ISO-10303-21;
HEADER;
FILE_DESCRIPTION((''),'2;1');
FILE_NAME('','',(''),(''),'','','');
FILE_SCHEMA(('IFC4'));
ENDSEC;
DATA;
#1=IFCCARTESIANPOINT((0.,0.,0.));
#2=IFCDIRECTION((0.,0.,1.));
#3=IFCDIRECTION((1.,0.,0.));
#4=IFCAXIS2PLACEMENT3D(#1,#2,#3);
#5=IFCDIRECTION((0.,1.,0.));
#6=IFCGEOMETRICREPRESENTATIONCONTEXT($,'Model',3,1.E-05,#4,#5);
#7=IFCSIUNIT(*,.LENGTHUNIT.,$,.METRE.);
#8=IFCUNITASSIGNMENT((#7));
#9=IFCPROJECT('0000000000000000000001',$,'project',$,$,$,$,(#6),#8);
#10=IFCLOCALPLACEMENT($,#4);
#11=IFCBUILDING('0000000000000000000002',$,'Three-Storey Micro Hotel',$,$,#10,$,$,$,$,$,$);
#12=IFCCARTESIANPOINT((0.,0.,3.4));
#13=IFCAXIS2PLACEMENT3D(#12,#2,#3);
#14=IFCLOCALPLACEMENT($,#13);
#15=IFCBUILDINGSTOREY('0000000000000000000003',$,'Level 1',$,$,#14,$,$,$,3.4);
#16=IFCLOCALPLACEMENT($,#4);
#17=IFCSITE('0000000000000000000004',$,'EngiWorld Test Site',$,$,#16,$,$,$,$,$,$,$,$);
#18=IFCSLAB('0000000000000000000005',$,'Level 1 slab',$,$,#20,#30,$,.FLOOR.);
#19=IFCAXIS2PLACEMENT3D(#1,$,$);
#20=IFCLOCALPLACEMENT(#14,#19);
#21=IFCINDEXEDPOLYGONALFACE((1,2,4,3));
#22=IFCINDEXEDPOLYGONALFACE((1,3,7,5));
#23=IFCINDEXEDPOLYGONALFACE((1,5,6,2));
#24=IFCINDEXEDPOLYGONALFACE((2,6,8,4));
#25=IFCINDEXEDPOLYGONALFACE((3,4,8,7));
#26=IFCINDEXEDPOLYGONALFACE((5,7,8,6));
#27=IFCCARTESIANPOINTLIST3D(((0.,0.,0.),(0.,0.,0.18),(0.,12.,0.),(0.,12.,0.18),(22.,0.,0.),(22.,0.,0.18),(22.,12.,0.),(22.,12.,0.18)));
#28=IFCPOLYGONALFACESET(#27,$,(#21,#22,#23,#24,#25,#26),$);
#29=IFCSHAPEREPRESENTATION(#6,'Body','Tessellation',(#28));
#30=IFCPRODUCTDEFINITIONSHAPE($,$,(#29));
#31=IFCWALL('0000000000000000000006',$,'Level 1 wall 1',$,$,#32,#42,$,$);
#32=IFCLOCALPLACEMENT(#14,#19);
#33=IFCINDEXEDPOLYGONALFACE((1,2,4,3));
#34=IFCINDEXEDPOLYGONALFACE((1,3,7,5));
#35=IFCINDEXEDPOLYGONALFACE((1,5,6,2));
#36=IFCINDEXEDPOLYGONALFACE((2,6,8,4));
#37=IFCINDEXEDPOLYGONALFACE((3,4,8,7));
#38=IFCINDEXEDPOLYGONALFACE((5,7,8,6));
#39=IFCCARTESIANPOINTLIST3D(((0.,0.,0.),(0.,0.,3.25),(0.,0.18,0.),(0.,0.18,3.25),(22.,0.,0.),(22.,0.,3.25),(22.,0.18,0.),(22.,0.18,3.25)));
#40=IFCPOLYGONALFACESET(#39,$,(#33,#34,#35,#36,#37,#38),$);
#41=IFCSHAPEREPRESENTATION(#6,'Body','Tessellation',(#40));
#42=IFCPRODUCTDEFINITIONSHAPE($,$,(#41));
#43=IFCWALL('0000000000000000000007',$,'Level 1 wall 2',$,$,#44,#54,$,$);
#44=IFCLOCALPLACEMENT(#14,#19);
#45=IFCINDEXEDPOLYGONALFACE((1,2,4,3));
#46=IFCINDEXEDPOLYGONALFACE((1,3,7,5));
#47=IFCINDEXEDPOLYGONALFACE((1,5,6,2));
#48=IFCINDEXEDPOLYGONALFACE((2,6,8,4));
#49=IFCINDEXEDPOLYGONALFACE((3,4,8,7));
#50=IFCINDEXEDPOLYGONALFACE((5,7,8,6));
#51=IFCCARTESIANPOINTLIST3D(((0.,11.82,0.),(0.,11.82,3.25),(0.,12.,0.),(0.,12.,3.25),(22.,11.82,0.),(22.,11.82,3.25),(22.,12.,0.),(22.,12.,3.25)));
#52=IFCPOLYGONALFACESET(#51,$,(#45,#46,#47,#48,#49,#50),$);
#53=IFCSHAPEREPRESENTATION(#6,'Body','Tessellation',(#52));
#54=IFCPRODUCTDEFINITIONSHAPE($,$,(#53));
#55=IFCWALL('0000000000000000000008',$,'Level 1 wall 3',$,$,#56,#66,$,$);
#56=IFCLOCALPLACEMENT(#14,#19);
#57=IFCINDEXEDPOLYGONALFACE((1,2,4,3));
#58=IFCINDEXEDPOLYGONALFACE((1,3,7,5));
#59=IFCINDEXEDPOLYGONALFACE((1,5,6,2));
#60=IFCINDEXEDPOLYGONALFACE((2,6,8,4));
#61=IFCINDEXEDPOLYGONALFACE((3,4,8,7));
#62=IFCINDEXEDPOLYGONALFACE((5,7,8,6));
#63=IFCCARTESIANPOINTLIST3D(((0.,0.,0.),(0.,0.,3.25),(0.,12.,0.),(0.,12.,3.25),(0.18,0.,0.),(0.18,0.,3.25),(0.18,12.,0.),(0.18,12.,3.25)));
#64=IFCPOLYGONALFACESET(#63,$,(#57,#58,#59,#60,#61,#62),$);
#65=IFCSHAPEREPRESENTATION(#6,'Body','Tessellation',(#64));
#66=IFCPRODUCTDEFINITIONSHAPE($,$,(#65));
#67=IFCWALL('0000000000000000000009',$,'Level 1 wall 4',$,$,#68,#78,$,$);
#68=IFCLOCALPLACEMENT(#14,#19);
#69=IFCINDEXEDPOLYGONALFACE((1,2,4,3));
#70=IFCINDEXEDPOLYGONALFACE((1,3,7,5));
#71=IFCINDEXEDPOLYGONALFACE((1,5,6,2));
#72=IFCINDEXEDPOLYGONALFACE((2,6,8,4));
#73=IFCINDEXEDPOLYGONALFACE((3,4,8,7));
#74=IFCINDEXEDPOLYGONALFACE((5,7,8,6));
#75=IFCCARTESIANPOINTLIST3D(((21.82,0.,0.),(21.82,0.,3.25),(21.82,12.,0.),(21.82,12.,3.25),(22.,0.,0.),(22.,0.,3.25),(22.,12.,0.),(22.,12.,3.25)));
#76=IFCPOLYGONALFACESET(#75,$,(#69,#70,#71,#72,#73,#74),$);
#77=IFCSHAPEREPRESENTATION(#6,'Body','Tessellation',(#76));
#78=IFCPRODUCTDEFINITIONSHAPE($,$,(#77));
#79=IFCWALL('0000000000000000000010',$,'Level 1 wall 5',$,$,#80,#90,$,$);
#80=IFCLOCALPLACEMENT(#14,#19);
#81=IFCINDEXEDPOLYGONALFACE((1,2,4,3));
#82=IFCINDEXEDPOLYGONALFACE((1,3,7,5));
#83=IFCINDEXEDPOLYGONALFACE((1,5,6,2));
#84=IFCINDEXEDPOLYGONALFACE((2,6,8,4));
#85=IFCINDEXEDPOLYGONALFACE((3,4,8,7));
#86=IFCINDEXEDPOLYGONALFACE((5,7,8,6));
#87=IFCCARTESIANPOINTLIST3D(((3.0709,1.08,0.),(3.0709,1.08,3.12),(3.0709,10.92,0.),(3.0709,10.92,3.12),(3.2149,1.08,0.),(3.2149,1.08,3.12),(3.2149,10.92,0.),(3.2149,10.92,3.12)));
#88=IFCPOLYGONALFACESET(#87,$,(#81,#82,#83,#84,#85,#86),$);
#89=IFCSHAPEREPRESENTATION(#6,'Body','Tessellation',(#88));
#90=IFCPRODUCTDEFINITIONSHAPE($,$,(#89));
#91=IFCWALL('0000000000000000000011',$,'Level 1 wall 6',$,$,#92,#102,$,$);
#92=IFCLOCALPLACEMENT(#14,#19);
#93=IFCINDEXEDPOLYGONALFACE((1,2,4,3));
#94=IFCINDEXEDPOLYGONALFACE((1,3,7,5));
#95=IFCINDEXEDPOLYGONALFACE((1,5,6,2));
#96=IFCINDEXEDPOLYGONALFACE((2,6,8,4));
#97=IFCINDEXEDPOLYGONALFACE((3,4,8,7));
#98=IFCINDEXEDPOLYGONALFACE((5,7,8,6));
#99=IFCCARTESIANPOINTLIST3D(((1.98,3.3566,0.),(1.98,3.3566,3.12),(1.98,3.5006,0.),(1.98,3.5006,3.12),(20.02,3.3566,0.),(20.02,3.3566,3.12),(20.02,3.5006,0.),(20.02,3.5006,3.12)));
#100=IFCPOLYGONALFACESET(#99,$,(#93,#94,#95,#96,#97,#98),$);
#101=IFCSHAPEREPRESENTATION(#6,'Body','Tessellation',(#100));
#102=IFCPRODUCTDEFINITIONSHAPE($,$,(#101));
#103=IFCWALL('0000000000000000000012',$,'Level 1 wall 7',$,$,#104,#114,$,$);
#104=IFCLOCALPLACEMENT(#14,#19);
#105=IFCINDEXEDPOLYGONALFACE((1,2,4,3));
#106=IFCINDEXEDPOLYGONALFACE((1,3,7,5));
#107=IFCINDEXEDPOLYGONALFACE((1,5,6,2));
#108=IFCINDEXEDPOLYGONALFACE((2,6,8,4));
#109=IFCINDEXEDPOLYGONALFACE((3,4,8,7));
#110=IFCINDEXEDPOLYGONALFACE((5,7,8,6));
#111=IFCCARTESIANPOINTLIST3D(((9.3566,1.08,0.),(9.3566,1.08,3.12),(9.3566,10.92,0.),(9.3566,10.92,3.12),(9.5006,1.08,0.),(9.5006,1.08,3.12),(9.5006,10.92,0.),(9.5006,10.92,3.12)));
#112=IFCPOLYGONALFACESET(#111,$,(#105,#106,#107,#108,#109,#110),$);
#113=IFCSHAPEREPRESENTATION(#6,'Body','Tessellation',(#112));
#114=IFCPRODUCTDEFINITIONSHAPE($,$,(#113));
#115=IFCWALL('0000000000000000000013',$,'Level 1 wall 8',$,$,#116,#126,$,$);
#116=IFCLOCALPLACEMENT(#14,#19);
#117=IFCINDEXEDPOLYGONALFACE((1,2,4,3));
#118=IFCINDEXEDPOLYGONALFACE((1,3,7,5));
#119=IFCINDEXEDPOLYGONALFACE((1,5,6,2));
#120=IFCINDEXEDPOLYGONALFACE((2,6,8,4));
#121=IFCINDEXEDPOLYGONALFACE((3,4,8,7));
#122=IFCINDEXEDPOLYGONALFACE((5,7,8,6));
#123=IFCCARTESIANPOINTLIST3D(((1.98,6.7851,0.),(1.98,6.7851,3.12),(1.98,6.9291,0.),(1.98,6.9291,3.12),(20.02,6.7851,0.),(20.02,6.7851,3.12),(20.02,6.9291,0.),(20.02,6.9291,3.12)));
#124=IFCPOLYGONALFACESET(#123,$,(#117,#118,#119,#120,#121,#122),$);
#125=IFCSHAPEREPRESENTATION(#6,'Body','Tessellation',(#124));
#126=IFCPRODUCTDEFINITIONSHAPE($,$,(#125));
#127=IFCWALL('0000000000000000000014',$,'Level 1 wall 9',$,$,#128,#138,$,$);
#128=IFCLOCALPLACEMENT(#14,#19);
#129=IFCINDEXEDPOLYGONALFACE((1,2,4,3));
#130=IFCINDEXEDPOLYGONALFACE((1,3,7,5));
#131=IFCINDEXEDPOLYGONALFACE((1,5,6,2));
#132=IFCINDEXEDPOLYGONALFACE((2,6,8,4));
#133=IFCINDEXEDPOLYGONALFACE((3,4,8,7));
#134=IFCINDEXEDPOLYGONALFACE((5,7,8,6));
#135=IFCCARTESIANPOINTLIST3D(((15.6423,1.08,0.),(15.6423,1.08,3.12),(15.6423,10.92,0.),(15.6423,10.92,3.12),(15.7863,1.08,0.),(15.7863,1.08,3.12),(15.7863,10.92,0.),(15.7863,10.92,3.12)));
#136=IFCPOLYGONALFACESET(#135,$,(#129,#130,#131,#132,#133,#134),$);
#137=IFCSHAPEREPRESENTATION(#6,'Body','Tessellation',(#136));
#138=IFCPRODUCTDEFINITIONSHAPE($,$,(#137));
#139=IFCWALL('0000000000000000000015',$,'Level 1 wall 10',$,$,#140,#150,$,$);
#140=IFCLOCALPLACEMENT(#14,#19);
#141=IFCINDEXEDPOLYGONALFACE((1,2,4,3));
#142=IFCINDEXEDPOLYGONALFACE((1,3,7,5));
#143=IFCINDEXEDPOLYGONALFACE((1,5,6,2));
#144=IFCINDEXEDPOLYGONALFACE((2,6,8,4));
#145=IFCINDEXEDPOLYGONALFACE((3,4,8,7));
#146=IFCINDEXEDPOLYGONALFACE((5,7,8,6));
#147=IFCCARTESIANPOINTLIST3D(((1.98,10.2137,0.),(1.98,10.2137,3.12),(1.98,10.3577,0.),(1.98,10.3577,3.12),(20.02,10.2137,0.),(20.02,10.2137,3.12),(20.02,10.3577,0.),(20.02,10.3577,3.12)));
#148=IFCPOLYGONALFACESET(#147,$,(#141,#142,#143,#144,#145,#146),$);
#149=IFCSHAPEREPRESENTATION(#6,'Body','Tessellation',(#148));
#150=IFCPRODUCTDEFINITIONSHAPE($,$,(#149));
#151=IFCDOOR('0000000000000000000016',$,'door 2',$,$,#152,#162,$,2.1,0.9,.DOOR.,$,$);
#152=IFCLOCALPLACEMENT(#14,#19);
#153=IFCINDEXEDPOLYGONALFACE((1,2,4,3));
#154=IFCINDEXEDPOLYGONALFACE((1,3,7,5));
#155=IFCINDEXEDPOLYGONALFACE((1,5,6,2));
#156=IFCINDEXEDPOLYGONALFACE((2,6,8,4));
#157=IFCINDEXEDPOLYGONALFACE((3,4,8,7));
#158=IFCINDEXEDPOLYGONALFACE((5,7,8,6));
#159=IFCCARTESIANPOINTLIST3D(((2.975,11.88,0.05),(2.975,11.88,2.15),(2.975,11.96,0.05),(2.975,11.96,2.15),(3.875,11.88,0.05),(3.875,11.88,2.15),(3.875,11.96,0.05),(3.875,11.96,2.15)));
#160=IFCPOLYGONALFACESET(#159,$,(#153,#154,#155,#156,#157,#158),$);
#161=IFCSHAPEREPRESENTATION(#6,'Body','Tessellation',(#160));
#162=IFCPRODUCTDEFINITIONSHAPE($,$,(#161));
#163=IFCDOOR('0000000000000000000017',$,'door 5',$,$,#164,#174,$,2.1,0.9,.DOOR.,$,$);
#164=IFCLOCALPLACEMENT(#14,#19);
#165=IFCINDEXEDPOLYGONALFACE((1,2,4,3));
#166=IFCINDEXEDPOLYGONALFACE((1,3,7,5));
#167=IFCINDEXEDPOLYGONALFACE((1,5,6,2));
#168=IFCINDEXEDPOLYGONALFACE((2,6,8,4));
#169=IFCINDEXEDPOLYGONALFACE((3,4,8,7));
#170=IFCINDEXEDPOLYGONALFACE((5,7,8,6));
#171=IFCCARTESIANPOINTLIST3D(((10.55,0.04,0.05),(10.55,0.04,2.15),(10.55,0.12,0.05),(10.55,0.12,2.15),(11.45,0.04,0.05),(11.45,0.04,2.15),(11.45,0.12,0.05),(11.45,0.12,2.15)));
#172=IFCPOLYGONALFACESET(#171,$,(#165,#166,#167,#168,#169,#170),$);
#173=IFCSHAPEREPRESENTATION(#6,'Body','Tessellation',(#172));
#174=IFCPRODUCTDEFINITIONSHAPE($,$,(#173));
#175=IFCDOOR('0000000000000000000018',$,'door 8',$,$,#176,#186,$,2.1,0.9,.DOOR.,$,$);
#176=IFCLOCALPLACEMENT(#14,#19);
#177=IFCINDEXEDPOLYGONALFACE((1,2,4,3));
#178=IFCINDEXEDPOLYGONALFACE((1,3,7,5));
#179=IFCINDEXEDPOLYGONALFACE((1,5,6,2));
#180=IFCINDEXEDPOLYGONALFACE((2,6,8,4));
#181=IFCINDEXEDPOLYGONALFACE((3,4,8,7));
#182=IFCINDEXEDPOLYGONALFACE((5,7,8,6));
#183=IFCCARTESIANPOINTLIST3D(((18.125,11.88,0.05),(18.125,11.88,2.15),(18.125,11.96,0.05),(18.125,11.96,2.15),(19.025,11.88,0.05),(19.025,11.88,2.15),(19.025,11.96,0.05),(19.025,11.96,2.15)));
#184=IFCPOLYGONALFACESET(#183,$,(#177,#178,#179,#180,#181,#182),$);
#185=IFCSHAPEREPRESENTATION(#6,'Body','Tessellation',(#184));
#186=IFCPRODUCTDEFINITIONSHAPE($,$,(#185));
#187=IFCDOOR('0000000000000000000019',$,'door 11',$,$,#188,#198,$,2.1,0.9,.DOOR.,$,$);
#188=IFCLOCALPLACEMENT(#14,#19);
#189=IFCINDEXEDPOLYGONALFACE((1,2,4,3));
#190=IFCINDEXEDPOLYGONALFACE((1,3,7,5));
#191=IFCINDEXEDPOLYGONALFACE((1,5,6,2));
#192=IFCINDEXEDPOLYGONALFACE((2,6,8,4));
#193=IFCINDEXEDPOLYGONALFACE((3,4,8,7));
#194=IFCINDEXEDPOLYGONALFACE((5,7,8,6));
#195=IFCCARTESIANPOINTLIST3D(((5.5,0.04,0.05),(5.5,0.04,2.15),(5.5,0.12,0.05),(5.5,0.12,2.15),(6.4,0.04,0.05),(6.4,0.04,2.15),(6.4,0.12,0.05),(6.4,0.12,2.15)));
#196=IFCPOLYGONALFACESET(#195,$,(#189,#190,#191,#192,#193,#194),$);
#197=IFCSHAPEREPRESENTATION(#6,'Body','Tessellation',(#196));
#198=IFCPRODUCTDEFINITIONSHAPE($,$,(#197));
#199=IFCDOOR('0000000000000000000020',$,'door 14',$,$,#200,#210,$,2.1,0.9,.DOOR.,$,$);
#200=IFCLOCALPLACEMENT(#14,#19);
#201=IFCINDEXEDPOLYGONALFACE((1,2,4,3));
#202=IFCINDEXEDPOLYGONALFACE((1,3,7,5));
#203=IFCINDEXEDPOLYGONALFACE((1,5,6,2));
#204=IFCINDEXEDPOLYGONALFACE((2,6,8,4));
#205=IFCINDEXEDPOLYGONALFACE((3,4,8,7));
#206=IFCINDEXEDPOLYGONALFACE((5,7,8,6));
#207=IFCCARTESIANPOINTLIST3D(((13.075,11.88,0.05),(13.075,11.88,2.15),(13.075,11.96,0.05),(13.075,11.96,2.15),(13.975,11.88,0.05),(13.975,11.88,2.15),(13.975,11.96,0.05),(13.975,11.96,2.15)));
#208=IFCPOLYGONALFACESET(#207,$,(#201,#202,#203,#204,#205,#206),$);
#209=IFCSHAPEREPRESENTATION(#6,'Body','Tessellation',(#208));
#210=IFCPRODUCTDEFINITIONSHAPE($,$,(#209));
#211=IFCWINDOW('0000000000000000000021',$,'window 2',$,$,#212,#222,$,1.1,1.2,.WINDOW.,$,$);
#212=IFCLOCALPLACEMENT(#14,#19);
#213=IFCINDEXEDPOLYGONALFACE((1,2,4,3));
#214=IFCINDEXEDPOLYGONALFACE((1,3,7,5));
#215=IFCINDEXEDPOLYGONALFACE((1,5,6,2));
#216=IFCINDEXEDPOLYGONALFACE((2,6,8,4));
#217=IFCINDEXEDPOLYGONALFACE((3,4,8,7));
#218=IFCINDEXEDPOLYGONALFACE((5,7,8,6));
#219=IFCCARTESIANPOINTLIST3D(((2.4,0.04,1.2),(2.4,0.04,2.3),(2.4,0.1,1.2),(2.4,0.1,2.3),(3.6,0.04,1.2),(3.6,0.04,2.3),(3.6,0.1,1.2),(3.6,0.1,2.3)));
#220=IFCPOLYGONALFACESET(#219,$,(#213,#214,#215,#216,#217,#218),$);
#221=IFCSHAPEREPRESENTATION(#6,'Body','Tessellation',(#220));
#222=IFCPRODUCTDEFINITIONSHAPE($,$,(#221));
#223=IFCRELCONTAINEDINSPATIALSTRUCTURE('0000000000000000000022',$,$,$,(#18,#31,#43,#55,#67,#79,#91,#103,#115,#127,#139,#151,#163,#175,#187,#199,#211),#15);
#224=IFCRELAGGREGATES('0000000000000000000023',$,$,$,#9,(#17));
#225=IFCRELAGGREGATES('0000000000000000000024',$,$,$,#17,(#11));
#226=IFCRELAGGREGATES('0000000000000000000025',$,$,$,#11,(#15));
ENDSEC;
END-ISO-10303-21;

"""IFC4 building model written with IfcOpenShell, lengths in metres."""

from ifc_helpers import new_model, si_unit, direction, frame, origin_with_axes, origin_2d_with_axis, place, context, project, spatial, rectangle, extrude, element, save


model = new_model("IFC4")

# Units and contexts
model_context = context("Model", 3, precision=1e-05, world=origin_with_axes(), true_north=direction((0.0, 1.0, 0.0)))
ifc_project = project(units=[si_unit("LENGTHUNIT", "METRE")], contexts=[model_context])

# Site, building, storey
site_placement = place(None, origin_with_axes())
site = spatial("IfcSite", under=ifc_project, at=site_placement, Name="EngiWorld Test Site")
building_placement = place(None, origin_with_axes())
building = spatial("IfcBuilding", under=site, at=building_placement, Name="Three-Storey Micro Hotel")
storey_placement = place(None, frame((0.0, 0.0, 3.4), z_axis=(0.0, 0.0, 1.0), x_axis=(1.0, 0.0, 0.0)))
storey = spatial("IfcBuildingStorey", under=building, at=storey_placement, Name="Level 1", Elevation=3.4)

# Slab
slab_placement = place(None, frame((11.0, 6.0, 3.4), z_axis=(0.0, 0.0, 1.0), x_axis=(1.0, 0.0, 0.0)))
element("IfcSlab", 1, at=slab_placement, inside=storey, Name="Level 1 slab", PredefinedType="FLOOR", context=model_context, shape_type="SweptSolid", body=[
    extrude(rectangle(XDim=22.0, YDim=12.0, at=origin_2d_with_axis()), origin_with_axes(), (0.0, 0.0, 1.0), 0.18),
])

# Walls
for number, where, z_axis, x_axis, name in (
    (2, (11.0, 0.09, 3.4), (0.0, 0.0, 1.0), (1.0, 0.0, 0.0), "Level 1 wall 1"),
    (3, (11.0, 11.91, 3.4), (0.0, 0.0, 1.0), (1.0, 0.0, 0.0), "Level 1 wall 2"),
):
    element("IfcWall", number, at=place(None, frame(where, z_axis=z_axis, x_axis=x_axis)), inside=storey, Name=name, context=model_context, shape_type="SweptSolid", body=[
        extrude(rectangle(XDim=22.0, YDim=0.18, at=origin_2d_with_axis()), origin_with_axes(), (0.0, 0.0, 1.0), 3.25),
    ])
for number, where, z_axis, x_axis, name in (
    (4, (0.09, 6.0, 3.4), (0.0, 0.0, 1.0), (1.0, 0.0, 0.0), "Level 1 wall 3"),
    (5, (21.91, 6.0, 3.4), (0.0, 0.0, 1.0), (1.0, 0.0, 0.0), "Level 1 wall 4"),
):
    element("IfcWall", number, at=place(None, frame(where, z_axis=z_axis, x_axis=x_axis)), inside=storey, Name=name, context=model_context, shape_type="SweptSolid", body=[
        extrude(rectangle(XDim=0.18, YDim=12.0, at=origin_2d_with_axis()), origin_with_axes(), (0.0, 0.0, 1.0), 3.25),
    ])
wall_1_placement = place(None, frame((3.1429, 6.0, 3.4), z_axis=(0.0, 0.0, 1.0), x_axis=(1.0, 0.0, 0.0)))
element("IfcWall", 6, at=wall_1_placement, inside=storey, Name="Level 1 wall 5", context=model_context, shape_type="SweptSolid", body=[
    extrude(rectangle(XDim=0.144, YDim=9.84, at=origin_2d_with_axis()), origin_with_axes(), (0.0, 0.0, 1.0), 3.12),
])
wall_2_placement = place(None, frame((11.0, 3.4286, 3.4), z_axis=(0.0, 0.0, 1.0), x_axis=(1.0, 0.0, 0.0)))
element("IfcWall", 7, at=wall_2_placement, inside=storey, Name="Level 1 wall 6", context=model_context, shape_type="SweptSolid", body=[
    extrude(rectangle(XDim=18.04, YDim=0.144, at=origin_2d_with_axis()), origin_with_axes(), (0.0, 0.0, 1.0), 3.12),
])
wall_3_placement = place(None, frame((9.4286, 6.0, 3.4), z_axis=(0.0, 0.0, 1.0), x_axis=(1.0, 0.0, 0.0)))
element("IfcWall", 8, at=wall_3_placement, inside=storey, Name="Level 1 wall 7", context=model_context, shape_type="SweptSolid", body=[
    extrude(rectangle(XDim=0.144, YDim=9.84, at=origin_2d_with_axis()), origin_with_axes(), (0.0, 0.0, 1.0), 3.12),
])
wall_4_placement = place(None, frame((11.0, 6.8571, 3.4), z_axis=(0.0, 0.0, 1.0), x_axis=(1.0, 0.0, 0.0)))
element("IfcWall", 9, at=wall_4_placement, inside=storey, Name="Level 1 wall 8", context=model_context, shape_type="SweptSolid", body=[
    extrude(rectangle(XDim=18.04, YDim=0.144, at=origin_2d_with_axis()), origin_with_axes(), (0.0, 0.0, 1.0), 3.12),
])
wall_5_placement = place(None, frame((15.7143, 6.0, 3.4), z_axis=(0.0, 0.0, 1.0), x_axis=(1.0, 0.0, 0.0)))
element("IfcWall", 10, at=wall_5_placement, inside=storey, Name="Level 1 wall 9", context=model_context, shape_type="SweptSolid", body=[
    extrude(rectangle(XDim=0.144, YDim=9.84, at=origin_2d_with_axis()), origin_with_axes(), (0.0, 0.0, 1.0), 3.12),
])
wall_6_placement = place(None, frame((11.0, 10.2857, 3.4), z_axis=(0.0, 0.0, 1.0), x_axis=(1.0, 0.0, 0.0)))
element("IfcWall", 11, at=wall_6_placement, inside=storey, Name="Level 1 wall 10", context=model_context, shape_type="SweptSolid", body=[
    extrude(rectangle(XDim=18.04, YDim=0.144, at=origin_2d_with_axis()), origin_with_axes(), (0.0, 0.0, 1.0), 3.12),
])

# Doors
for number, where, z_axis, x_axis, name in (
    (12, (3.425, 11.92, 3.45), (0.0, 0.0, 1.0), (1.0, 0.0, 0.0), "door 2"),
    (13, (11.0, 0.08, 3.45), (0.0, 0.0, 1.0), (1.0, 0.0, 0.0), "door 5"),
    (14, (18.575, 11.92, 3.45), (0.0, 0.0, 1.0), (1.0, 0.0, 0.0), "door 8"),
    (15, (5.95, 0.08, 3.45), (0.0, 0.0, 1.0), (1.0, 0.0, 0.0), "door 11"),
    (16, (13.525, 11.92, 3.45), (0.0, 0.0, 1.0), (1.0, 0.0, 0.0), "door 14"),
):
    element("IfcDoor", number, at=place(None, frame(where, z_axis=z_axis, x_axis=x_axis)), inside=storey, Name=name, OverallHeight=2.1, OverallWidth=0.9, PredefinedType="DOOR", context=model_context, shape_type="SweptSolid", body=[
        extrude(rectangle(XDim=0.9, YDim=0.08, at=origin_2d_with_axis()), origin_with_axes(), (0.0, 0.0, 1.0), 2.1),
    ])

# Window
for number, where, z_axis, x_axis, name in (
    (17, (3.0, 0.07, 4.6), (0.0, 0.0, 1.0), (1.0, 0.0, 0.0), "window 2"),
):
    element("IfcWindow", number, at=place(None, frame(where, z_axis=z_axis, x_axis=x_axis)), inside=storey, Name=name, OverallHeight=1.1, OverallWidth=1.2, PredefinedType="WINDOW", context=model_context, shape_type="SweptSolid", body=[
        extrude(rectangle(XDim=1.2, YDim=0.06, at=origin_2d_with_axis()), origin_with_axes(), (0.0, 0.0, 1.0), 1.1),
    ])

save(model, "model.ifc")
